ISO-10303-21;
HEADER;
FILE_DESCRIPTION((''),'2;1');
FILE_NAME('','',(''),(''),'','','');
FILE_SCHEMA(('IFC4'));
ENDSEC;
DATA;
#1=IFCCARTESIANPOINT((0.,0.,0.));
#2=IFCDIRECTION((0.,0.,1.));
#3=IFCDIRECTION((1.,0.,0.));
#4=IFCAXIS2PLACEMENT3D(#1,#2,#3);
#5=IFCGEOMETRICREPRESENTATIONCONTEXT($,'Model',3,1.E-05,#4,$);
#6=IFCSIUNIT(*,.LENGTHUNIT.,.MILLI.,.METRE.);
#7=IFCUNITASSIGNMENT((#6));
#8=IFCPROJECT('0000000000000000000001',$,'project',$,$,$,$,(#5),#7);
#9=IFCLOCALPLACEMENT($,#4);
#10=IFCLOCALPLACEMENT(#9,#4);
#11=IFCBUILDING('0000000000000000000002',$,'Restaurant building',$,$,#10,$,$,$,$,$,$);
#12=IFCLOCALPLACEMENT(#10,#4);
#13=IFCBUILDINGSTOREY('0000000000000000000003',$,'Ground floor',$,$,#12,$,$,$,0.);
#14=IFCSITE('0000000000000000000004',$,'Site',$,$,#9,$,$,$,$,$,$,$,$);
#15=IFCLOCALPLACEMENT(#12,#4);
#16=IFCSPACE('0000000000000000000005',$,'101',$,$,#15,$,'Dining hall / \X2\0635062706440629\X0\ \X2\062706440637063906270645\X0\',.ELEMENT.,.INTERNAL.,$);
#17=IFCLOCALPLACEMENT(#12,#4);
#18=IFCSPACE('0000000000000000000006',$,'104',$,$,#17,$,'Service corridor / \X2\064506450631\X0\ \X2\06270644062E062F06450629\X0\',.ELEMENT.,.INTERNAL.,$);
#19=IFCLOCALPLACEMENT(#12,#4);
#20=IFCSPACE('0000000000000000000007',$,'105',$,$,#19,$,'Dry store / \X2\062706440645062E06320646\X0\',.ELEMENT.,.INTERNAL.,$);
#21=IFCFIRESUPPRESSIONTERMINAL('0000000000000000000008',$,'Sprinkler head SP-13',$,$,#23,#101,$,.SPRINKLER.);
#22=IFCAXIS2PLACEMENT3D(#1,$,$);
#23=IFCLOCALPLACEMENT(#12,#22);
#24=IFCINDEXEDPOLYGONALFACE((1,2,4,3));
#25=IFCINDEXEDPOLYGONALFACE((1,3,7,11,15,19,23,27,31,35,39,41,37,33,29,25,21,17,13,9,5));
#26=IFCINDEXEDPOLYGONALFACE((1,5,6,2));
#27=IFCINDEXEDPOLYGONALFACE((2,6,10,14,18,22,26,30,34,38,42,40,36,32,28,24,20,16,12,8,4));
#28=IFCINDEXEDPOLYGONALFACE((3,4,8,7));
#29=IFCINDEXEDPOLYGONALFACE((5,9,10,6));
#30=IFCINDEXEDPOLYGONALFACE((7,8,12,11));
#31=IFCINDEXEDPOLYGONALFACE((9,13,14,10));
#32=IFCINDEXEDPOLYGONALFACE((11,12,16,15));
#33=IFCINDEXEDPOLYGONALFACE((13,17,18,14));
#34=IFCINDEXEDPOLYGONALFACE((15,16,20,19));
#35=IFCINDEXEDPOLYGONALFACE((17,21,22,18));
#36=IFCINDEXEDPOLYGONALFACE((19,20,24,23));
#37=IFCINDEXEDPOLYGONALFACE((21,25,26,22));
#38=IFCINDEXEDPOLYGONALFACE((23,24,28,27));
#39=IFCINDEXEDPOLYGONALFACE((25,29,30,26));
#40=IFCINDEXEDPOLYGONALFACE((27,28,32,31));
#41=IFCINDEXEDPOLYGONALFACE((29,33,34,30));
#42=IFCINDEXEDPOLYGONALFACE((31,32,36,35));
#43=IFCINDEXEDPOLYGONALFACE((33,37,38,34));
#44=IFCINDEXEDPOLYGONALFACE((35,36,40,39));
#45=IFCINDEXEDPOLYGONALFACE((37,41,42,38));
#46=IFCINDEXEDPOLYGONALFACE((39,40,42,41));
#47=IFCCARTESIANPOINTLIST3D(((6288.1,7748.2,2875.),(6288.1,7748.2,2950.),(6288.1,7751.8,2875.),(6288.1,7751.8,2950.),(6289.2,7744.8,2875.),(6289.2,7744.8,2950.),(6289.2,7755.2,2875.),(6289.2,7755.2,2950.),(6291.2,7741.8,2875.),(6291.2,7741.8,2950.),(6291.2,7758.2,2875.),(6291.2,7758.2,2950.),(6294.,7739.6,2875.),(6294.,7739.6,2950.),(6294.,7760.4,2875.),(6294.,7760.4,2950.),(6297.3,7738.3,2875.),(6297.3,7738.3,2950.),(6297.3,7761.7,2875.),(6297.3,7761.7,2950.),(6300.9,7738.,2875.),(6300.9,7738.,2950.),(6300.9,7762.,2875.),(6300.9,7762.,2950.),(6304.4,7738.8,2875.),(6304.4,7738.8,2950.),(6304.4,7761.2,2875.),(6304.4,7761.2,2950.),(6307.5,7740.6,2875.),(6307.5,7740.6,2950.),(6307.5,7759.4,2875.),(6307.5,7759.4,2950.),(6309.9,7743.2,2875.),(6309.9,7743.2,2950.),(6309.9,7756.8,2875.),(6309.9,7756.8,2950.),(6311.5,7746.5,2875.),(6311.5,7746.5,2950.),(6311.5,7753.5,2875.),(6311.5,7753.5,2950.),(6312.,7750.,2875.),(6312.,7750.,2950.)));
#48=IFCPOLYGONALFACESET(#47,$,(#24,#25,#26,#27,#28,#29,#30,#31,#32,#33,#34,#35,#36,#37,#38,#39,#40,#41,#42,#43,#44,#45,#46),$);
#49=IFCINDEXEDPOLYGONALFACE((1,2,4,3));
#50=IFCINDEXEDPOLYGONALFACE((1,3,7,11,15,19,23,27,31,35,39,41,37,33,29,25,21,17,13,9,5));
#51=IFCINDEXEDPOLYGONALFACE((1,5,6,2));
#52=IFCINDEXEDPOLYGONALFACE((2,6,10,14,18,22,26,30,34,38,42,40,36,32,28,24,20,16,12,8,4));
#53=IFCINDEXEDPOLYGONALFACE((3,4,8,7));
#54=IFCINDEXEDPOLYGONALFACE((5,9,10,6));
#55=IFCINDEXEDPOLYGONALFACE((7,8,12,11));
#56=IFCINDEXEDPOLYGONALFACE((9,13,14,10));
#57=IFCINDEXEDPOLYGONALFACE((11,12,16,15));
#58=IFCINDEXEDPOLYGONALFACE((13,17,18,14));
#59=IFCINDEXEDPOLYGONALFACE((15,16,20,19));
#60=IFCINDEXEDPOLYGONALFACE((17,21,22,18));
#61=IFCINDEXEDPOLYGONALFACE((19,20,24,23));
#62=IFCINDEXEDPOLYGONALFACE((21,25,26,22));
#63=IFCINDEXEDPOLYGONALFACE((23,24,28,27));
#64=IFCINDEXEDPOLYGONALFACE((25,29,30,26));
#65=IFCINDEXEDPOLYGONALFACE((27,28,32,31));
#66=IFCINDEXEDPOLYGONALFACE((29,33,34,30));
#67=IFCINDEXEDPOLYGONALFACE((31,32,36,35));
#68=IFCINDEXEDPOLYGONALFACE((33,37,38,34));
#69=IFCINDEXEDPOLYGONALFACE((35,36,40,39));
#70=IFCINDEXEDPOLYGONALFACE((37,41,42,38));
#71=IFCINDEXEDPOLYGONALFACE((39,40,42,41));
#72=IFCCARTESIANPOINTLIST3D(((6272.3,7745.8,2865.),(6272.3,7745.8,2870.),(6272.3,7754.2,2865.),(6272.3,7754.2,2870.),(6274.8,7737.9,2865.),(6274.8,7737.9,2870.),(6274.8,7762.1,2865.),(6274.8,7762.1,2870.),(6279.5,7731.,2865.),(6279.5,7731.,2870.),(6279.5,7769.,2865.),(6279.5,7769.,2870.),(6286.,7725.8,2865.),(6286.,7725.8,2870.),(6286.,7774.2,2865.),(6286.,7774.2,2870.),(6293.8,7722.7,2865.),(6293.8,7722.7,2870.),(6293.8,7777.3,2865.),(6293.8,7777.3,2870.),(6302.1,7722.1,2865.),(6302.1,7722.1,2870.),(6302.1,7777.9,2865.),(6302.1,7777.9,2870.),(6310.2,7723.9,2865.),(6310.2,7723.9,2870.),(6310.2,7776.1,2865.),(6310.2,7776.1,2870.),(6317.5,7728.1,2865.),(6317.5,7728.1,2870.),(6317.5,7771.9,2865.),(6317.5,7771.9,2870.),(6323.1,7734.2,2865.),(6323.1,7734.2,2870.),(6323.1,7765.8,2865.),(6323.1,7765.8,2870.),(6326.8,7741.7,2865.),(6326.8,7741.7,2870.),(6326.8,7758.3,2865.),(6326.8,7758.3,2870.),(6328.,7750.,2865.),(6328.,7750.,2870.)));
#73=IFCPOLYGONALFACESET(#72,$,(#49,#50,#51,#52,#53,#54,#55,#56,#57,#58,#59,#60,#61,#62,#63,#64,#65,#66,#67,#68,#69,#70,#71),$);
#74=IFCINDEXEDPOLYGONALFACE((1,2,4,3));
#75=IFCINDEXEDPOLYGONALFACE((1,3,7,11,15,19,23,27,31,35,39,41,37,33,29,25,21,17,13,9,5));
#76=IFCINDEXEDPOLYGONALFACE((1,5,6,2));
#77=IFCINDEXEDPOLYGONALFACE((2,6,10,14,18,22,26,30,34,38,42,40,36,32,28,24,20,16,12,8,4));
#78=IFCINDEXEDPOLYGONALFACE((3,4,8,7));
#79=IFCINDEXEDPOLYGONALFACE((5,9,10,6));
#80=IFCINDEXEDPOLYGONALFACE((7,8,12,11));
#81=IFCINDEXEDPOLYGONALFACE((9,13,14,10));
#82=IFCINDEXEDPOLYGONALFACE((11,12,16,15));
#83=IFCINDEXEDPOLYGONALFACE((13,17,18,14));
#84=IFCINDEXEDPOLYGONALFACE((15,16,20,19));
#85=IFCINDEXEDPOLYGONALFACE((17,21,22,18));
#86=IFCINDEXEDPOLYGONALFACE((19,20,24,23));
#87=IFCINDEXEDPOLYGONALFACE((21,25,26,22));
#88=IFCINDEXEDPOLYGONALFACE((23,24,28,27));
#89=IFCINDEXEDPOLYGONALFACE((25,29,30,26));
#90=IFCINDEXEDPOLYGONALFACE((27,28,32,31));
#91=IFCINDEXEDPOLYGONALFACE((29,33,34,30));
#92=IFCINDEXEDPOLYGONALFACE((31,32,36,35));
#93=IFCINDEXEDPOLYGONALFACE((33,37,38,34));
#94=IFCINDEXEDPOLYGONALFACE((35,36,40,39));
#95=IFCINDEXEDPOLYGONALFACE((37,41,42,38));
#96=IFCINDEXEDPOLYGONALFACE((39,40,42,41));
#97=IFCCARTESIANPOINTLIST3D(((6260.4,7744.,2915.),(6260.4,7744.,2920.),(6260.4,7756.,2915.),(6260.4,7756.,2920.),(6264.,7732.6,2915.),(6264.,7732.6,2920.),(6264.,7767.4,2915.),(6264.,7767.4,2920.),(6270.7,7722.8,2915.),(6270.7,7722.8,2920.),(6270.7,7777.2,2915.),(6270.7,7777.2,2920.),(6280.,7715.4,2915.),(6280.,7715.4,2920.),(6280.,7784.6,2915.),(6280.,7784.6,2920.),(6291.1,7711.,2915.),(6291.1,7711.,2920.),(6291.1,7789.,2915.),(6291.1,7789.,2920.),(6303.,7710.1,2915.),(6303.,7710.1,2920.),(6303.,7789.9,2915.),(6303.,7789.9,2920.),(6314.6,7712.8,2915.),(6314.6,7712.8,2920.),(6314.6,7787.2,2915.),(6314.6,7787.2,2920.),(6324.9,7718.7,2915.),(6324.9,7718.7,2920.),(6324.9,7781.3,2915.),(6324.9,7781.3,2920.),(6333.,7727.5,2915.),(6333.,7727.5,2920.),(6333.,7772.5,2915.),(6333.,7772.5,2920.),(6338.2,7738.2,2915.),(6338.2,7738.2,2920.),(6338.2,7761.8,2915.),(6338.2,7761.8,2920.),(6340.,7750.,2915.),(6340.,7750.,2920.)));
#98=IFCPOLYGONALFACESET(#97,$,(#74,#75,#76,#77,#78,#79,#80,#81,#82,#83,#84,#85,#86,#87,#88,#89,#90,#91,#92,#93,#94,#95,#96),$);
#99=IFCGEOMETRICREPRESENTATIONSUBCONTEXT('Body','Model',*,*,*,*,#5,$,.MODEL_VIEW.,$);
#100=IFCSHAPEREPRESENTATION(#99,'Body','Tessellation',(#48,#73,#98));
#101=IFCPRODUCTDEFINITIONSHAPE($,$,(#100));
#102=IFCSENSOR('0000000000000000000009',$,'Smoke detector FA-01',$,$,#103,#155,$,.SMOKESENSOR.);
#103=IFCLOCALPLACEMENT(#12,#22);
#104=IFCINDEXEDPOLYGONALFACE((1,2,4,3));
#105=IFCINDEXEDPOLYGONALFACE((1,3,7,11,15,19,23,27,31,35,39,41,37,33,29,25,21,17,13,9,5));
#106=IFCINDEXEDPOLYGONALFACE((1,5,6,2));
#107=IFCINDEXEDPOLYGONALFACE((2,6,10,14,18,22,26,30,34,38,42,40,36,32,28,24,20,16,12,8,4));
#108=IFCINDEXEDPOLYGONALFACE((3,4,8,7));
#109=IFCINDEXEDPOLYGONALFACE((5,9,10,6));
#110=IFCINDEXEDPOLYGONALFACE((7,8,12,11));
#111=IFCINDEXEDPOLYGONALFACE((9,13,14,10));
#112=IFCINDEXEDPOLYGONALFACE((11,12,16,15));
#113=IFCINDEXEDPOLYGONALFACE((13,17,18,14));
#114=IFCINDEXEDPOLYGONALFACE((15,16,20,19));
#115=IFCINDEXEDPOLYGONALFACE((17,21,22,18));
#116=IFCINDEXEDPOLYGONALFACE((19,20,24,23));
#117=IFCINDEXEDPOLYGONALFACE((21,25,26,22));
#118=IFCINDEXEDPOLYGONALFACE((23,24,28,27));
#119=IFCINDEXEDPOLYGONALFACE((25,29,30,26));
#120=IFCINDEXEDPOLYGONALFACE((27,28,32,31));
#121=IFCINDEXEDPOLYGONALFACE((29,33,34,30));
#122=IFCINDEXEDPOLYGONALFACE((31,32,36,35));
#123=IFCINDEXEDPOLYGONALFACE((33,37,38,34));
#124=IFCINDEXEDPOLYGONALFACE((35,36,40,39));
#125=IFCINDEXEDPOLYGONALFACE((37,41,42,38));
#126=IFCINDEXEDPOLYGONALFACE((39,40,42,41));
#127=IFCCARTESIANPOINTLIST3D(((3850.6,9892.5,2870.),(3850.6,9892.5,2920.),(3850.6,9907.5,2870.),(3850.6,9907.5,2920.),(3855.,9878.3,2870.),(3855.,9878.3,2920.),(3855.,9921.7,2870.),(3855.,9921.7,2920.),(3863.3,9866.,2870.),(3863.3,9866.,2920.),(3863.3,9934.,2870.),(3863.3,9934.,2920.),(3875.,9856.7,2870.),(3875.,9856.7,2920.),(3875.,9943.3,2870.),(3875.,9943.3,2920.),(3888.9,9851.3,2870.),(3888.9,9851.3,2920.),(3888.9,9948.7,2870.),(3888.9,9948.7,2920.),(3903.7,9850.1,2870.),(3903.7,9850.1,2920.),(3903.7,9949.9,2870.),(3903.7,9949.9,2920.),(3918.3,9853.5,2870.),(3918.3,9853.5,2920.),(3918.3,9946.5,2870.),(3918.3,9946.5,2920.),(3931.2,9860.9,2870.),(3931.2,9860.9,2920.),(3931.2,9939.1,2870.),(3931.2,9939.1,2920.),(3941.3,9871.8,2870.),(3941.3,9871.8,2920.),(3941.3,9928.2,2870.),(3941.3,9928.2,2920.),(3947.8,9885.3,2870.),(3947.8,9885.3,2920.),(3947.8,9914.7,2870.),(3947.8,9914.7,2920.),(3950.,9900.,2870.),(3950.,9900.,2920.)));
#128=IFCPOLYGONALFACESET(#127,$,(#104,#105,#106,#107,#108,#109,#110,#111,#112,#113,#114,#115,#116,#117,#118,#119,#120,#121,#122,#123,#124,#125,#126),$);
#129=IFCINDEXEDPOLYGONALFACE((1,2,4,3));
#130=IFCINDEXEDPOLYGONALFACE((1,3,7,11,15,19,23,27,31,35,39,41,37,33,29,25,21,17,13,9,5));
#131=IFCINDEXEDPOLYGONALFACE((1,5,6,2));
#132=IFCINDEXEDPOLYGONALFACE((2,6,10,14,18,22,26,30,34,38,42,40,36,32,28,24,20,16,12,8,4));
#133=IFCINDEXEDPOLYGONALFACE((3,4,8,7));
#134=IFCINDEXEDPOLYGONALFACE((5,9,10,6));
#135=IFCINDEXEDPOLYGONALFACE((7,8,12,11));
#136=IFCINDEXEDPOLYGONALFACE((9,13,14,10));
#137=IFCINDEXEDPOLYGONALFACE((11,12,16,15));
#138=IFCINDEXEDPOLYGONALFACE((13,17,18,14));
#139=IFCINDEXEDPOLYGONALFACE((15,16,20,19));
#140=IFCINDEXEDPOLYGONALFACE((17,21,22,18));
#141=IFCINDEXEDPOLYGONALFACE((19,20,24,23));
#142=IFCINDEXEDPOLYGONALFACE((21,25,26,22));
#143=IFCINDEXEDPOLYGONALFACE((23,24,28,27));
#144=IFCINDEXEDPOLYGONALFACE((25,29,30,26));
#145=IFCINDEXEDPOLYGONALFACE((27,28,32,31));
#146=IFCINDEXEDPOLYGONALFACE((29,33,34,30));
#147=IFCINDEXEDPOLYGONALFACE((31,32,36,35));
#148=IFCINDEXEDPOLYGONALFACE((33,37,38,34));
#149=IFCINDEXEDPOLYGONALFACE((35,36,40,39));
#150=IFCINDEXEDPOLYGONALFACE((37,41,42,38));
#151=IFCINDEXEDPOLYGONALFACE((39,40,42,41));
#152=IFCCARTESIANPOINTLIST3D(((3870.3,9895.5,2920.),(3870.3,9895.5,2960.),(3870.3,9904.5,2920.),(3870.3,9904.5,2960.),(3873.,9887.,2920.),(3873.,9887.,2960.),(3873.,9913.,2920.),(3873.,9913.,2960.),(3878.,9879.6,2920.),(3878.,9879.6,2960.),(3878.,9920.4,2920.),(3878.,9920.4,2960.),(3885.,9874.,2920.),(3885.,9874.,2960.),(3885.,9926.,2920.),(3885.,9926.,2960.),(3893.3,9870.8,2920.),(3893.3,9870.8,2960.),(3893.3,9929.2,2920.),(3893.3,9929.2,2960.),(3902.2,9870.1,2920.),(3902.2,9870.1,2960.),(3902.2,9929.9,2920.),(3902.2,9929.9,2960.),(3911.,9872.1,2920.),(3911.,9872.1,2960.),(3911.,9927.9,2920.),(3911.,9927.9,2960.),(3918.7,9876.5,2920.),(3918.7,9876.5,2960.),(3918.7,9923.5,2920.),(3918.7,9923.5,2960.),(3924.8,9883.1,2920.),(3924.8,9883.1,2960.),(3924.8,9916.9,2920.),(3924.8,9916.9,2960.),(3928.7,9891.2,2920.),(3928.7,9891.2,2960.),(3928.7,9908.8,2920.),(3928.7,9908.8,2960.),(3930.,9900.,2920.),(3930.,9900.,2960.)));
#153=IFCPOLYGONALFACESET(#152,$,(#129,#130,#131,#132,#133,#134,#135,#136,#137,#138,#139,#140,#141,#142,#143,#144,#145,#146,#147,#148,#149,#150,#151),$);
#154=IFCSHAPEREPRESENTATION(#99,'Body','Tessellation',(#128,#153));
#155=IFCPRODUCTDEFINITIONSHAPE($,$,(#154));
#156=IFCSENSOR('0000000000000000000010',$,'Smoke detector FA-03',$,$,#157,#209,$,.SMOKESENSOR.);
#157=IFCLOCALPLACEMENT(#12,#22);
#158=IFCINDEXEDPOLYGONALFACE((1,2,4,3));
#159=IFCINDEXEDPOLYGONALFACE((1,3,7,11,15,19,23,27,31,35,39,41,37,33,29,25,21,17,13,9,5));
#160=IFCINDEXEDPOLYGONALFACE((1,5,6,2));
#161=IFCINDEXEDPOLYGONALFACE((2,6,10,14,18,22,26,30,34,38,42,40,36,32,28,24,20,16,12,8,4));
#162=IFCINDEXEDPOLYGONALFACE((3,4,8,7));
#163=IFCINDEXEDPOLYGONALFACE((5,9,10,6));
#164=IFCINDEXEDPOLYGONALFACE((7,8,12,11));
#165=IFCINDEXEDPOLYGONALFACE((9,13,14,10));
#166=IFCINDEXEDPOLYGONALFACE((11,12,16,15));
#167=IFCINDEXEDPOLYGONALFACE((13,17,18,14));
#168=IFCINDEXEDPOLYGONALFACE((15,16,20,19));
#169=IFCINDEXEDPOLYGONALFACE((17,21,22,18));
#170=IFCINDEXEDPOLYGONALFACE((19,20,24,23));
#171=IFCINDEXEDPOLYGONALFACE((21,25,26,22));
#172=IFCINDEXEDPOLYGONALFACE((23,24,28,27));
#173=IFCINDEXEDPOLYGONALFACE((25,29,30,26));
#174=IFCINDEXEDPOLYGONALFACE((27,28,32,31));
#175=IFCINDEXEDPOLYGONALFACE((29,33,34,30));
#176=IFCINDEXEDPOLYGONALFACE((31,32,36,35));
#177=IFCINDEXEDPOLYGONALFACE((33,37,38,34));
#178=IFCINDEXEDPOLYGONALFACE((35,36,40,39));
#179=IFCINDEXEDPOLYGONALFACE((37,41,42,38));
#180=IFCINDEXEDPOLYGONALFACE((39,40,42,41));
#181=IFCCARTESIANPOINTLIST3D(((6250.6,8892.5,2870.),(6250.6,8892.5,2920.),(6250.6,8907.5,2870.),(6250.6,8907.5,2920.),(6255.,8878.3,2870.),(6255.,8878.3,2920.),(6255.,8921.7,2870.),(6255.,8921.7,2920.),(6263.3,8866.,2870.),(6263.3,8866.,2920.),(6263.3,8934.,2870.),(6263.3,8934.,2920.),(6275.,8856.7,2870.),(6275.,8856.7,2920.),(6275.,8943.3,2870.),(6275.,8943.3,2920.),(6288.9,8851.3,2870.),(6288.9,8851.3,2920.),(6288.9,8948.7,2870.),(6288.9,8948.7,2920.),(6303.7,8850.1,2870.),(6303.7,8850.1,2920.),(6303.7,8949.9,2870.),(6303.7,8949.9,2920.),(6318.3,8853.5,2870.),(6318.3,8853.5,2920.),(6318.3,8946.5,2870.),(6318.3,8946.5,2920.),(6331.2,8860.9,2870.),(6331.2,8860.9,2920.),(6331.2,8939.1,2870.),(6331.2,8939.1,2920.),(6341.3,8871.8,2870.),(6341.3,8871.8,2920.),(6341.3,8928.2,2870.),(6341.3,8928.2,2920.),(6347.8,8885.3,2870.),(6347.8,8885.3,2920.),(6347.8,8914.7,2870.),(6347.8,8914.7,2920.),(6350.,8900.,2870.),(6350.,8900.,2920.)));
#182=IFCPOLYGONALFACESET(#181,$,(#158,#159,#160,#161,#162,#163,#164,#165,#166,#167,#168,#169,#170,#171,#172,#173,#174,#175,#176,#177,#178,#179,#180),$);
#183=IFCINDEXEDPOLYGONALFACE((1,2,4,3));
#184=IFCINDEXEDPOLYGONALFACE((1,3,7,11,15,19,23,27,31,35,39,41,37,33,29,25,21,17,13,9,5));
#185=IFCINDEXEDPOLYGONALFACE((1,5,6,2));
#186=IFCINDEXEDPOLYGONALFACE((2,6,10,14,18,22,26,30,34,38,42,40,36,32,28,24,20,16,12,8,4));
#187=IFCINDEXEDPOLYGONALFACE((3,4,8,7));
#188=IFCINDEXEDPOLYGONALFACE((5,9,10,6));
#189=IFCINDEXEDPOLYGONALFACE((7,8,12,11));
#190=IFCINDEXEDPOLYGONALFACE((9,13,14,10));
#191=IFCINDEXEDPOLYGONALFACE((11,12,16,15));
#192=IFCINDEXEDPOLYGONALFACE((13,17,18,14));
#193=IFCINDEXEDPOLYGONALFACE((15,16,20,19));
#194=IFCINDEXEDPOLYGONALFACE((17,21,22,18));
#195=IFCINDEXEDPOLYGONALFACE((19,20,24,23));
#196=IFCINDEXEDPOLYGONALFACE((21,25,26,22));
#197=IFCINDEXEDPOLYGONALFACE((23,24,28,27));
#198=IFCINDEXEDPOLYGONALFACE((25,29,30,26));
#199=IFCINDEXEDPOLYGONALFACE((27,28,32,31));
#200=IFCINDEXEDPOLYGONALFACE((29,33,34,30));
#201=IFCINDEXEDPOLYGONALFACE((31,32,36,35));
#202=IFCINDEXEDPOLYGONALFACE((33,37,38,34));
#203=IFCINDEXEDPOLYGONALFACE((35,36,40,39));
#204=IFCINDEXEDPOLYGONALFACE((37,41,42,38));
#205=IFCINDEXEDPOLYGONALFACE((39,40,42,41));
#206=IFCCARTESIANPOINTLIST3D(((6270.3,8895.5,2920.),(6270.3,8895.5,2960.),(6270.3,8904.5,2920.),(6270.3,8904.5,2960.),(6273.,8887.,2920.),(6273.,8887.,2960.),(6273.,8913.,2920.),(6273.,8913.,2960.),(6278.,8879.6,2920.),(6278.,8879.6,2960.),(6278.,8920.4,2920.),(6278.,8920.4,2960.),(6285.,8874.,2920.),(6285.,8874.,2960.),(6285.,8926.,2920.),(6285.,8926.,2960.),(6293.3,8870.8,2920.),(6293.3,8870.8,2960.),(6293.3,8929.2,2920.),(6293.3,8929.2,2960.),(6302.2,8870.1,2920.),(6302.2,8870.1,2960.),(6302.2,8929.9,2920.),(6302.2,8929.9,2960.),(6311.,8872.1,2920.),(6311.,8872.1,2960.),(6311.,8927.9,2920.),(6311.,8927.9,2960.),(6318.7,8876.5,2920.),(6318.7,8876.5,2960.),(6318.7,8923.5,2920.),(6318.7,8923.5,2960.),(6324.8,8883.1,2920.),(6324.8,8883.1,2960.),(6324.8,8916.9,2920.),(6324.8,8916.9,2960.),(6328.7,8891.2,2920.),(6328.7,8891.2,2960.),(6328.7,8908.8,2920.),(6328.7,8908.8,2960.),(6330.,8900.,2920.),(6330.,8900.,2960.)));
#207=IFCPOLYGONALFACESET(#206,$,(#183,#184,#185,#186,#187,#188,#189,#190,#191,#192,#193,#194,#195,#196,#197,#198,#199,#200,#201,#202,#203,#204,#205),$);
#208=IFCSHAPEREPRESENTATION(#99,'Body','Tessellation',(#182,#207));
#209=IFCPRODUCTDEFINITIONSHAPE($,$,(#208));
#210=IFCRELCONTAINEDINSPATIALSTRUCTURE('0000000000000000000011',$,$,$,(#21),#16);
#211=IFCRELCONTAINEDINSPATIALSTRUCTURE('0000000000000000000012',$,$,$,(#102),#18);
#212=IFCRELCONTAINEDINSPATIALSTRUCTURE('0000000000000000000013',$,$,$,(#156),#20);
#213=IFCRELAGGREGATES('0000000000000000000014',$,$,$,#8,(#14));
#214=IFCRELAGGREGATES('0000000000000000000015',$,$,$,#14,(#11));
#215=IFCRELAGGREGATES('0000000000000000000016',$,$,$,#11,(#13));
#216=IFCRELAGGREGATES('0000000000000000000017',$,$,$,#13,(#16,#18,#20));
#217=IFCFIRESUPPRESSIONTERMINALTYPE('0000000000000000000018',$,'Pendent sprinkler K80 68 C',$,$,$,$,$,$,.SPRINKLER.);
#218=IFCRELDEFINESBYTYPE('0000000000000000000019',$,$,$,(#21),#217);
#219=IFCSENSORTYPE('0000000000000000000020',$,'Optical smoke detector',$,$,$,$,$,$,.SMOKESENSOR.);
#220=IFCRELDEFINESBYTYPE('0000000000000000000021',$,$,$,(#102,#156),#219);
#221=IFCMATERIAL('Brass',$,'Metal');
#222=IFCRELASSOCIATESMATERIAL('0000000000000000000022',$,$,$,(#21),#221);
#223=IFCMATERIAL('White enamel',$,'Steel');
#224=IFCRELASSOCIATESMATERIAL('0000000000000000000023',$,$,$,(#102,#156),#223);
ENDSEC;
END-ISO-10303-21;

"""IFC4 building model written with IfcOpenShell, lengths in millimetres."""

from ifc_helpers import new_model, si_unit, frame, origin, origin_with_axes, origin_2d, place, context, subcontext, project, spatial, circle, extrude, source, transform, mapped, material, type_object, type_shapes, element, save


model = new_model("IFC4")

# Units and contexts
model_context = context("Model", 3, precision=1e-05, world=origin_with_axes())
body_context = subcontext(model_context, "Body", "Model", "MODEL_VIEW")
ifc_project = project(units=[si_unit("LENGTHUNIT", "METRE", prefix="MILLI")], contexts=[model_context])

# Site, building, storey
site_placement = place(None, origin_with_axes())
site = spatial("IfcSite", under=ifc_project, at=site_placement, Name="Site")
building_placement = place(site_placement, origin_with_axes())
building = spatial("IfcBuilding", under=site, at=building_placement, Name="Restaurant building")
storey_placement = place(building_placement, origin_with_axes())
storey = spatial("IfcBuildingStorey", under=building, at=storey_placement, Name="Ground floor", Elevation=0.0)

# Shared definitions
ifc_material_1 = material(Name="White enamel", Category="Steel")

# Shared definitions
space_1_placement = place(storey_placement, origin_with_axes())
space_1 = spatial("IfcSpace", under=storey, at=space_1_placement, Name="101", LongName="Dining hall / صالة الطعام", CompositionType="ELEMENT", PredefinedType="INTERNAL")

# Shared definitions
space_2_placement = place(storey_placement, origin_with_axes())
space_2 = spatial("IfcSpace", under=storey, at=space_2_placement, Name="104", LongName="Service corridor / ممر الخدمة", CompositionType="ELEMENT", PredefinedType="INTERNAL")

# Fire suppression terminal
ifc_material_2 = material(Name="Brass", Category="Metal")
fire_suppression_terminal_type = type_object("IfcFireSuppressionTerminalType", Name="Pendent sprinkler K80 68 C", PredefinedType="SPRINKLER")
shared_shape_1 = source(origin(), body_context, "Body", "SweptSolid", [
    extrude(circle(Radius=12.0, at=origin_2d()), frame((0.0, 0.0, -75.0)), (0.0, 0.0, 1.0), 75.0),
    extrude(circle(Radius=28.0, at=origin_2d()), frame((0.0, 0.0, -85.0)), (0.0, 0.0, 1.0), 5.0),
    extrude(circle(Radius=40.0, at=origin_2d()), frame((0.0, 0.0, -35.0)), (0.0, 0.0, 1.0), 5.0),
])
type_shapes(fire_suppression_terminal_type, [shared_shape_1])
for number, where, name in (
    (1, (6300.0, 7750.0, 2950.0), "Sprinkler head SP-13"),
):
    element("IfcFireSuppressionTerminal", number, at=place(storey_placement, frame(where)), inside=space_1, type_object=fire_suppression_terminal_type, material=ifc_material_2, Name=name, PredefinedType="SPRINKLER", context=body_context, shape_type="MappedRepresentation", body=[
        mapped(shared_shape_1, transform((0.0, 0.0, 0.0))),
    ])

# Sensor
sensor_type = type_object("IfcSensorType", Name="Optical smoke detector", PredefinedType="SMOKESENSOR")
shared_shape_2 = source(origin(), body_context, "Body", "SweptSolid", [
    extrude(circle(Radius=50.0, at=origin_2d()), frame((0.0, 0.0, -90.0)), (0.0, 0.0, 1.0), 50.0),
    extrude(circle(Radius=30.0, at=origin_2d()), frame((0.0, 0.0, -40.0)), (0.0, 0.0, 1.0), 40.0),
])
type_shapes(sensor_type, [shared_shape_2])
sensor_1_placement = place(storey_placement, frame((3900.0, 9900.0, 2960.0)))
element("IfcSensor", 2, at=sensor_1_placement, inside=space_2, type_object=sensor_type, material=ifc_material_1, Name="Smoke detector FA-01", PredefinedType="SMOKESENSOR", context=body_context, shape_type="MappedRepresentation", body=[
    mapped(shared_shape_2, transform((0.0, 0.0, 0.0))),
])

# Shared definitions
space_3_placement = place(storey_placement, origin_with_axes())
space_3 = spatial("IfcSpace", under=storey, at=space_3_placement, Name="105", LongName="Dry store / المخزن", CompositionType="ELEMENT", PredefinedType="INTERNAL")

# Sensor
sensor_2_placement = place(storey_placement, frame((6300.0, 8900.0, 2960.0)))
element("IfcSensor", 3, at=sensor_2_placement, inside=space_3, type_object=sensor_type, material=ifc_material_1, Name="Smoke detector FA-03", PredefinedType="SMOKESENSOR", context=body_context, shape_type="MappedRepresentation", body=[
    mapped(shared_shape_2, transform((0.0, 0.0, 0.0))),
])

save(model, "model.ifc")
